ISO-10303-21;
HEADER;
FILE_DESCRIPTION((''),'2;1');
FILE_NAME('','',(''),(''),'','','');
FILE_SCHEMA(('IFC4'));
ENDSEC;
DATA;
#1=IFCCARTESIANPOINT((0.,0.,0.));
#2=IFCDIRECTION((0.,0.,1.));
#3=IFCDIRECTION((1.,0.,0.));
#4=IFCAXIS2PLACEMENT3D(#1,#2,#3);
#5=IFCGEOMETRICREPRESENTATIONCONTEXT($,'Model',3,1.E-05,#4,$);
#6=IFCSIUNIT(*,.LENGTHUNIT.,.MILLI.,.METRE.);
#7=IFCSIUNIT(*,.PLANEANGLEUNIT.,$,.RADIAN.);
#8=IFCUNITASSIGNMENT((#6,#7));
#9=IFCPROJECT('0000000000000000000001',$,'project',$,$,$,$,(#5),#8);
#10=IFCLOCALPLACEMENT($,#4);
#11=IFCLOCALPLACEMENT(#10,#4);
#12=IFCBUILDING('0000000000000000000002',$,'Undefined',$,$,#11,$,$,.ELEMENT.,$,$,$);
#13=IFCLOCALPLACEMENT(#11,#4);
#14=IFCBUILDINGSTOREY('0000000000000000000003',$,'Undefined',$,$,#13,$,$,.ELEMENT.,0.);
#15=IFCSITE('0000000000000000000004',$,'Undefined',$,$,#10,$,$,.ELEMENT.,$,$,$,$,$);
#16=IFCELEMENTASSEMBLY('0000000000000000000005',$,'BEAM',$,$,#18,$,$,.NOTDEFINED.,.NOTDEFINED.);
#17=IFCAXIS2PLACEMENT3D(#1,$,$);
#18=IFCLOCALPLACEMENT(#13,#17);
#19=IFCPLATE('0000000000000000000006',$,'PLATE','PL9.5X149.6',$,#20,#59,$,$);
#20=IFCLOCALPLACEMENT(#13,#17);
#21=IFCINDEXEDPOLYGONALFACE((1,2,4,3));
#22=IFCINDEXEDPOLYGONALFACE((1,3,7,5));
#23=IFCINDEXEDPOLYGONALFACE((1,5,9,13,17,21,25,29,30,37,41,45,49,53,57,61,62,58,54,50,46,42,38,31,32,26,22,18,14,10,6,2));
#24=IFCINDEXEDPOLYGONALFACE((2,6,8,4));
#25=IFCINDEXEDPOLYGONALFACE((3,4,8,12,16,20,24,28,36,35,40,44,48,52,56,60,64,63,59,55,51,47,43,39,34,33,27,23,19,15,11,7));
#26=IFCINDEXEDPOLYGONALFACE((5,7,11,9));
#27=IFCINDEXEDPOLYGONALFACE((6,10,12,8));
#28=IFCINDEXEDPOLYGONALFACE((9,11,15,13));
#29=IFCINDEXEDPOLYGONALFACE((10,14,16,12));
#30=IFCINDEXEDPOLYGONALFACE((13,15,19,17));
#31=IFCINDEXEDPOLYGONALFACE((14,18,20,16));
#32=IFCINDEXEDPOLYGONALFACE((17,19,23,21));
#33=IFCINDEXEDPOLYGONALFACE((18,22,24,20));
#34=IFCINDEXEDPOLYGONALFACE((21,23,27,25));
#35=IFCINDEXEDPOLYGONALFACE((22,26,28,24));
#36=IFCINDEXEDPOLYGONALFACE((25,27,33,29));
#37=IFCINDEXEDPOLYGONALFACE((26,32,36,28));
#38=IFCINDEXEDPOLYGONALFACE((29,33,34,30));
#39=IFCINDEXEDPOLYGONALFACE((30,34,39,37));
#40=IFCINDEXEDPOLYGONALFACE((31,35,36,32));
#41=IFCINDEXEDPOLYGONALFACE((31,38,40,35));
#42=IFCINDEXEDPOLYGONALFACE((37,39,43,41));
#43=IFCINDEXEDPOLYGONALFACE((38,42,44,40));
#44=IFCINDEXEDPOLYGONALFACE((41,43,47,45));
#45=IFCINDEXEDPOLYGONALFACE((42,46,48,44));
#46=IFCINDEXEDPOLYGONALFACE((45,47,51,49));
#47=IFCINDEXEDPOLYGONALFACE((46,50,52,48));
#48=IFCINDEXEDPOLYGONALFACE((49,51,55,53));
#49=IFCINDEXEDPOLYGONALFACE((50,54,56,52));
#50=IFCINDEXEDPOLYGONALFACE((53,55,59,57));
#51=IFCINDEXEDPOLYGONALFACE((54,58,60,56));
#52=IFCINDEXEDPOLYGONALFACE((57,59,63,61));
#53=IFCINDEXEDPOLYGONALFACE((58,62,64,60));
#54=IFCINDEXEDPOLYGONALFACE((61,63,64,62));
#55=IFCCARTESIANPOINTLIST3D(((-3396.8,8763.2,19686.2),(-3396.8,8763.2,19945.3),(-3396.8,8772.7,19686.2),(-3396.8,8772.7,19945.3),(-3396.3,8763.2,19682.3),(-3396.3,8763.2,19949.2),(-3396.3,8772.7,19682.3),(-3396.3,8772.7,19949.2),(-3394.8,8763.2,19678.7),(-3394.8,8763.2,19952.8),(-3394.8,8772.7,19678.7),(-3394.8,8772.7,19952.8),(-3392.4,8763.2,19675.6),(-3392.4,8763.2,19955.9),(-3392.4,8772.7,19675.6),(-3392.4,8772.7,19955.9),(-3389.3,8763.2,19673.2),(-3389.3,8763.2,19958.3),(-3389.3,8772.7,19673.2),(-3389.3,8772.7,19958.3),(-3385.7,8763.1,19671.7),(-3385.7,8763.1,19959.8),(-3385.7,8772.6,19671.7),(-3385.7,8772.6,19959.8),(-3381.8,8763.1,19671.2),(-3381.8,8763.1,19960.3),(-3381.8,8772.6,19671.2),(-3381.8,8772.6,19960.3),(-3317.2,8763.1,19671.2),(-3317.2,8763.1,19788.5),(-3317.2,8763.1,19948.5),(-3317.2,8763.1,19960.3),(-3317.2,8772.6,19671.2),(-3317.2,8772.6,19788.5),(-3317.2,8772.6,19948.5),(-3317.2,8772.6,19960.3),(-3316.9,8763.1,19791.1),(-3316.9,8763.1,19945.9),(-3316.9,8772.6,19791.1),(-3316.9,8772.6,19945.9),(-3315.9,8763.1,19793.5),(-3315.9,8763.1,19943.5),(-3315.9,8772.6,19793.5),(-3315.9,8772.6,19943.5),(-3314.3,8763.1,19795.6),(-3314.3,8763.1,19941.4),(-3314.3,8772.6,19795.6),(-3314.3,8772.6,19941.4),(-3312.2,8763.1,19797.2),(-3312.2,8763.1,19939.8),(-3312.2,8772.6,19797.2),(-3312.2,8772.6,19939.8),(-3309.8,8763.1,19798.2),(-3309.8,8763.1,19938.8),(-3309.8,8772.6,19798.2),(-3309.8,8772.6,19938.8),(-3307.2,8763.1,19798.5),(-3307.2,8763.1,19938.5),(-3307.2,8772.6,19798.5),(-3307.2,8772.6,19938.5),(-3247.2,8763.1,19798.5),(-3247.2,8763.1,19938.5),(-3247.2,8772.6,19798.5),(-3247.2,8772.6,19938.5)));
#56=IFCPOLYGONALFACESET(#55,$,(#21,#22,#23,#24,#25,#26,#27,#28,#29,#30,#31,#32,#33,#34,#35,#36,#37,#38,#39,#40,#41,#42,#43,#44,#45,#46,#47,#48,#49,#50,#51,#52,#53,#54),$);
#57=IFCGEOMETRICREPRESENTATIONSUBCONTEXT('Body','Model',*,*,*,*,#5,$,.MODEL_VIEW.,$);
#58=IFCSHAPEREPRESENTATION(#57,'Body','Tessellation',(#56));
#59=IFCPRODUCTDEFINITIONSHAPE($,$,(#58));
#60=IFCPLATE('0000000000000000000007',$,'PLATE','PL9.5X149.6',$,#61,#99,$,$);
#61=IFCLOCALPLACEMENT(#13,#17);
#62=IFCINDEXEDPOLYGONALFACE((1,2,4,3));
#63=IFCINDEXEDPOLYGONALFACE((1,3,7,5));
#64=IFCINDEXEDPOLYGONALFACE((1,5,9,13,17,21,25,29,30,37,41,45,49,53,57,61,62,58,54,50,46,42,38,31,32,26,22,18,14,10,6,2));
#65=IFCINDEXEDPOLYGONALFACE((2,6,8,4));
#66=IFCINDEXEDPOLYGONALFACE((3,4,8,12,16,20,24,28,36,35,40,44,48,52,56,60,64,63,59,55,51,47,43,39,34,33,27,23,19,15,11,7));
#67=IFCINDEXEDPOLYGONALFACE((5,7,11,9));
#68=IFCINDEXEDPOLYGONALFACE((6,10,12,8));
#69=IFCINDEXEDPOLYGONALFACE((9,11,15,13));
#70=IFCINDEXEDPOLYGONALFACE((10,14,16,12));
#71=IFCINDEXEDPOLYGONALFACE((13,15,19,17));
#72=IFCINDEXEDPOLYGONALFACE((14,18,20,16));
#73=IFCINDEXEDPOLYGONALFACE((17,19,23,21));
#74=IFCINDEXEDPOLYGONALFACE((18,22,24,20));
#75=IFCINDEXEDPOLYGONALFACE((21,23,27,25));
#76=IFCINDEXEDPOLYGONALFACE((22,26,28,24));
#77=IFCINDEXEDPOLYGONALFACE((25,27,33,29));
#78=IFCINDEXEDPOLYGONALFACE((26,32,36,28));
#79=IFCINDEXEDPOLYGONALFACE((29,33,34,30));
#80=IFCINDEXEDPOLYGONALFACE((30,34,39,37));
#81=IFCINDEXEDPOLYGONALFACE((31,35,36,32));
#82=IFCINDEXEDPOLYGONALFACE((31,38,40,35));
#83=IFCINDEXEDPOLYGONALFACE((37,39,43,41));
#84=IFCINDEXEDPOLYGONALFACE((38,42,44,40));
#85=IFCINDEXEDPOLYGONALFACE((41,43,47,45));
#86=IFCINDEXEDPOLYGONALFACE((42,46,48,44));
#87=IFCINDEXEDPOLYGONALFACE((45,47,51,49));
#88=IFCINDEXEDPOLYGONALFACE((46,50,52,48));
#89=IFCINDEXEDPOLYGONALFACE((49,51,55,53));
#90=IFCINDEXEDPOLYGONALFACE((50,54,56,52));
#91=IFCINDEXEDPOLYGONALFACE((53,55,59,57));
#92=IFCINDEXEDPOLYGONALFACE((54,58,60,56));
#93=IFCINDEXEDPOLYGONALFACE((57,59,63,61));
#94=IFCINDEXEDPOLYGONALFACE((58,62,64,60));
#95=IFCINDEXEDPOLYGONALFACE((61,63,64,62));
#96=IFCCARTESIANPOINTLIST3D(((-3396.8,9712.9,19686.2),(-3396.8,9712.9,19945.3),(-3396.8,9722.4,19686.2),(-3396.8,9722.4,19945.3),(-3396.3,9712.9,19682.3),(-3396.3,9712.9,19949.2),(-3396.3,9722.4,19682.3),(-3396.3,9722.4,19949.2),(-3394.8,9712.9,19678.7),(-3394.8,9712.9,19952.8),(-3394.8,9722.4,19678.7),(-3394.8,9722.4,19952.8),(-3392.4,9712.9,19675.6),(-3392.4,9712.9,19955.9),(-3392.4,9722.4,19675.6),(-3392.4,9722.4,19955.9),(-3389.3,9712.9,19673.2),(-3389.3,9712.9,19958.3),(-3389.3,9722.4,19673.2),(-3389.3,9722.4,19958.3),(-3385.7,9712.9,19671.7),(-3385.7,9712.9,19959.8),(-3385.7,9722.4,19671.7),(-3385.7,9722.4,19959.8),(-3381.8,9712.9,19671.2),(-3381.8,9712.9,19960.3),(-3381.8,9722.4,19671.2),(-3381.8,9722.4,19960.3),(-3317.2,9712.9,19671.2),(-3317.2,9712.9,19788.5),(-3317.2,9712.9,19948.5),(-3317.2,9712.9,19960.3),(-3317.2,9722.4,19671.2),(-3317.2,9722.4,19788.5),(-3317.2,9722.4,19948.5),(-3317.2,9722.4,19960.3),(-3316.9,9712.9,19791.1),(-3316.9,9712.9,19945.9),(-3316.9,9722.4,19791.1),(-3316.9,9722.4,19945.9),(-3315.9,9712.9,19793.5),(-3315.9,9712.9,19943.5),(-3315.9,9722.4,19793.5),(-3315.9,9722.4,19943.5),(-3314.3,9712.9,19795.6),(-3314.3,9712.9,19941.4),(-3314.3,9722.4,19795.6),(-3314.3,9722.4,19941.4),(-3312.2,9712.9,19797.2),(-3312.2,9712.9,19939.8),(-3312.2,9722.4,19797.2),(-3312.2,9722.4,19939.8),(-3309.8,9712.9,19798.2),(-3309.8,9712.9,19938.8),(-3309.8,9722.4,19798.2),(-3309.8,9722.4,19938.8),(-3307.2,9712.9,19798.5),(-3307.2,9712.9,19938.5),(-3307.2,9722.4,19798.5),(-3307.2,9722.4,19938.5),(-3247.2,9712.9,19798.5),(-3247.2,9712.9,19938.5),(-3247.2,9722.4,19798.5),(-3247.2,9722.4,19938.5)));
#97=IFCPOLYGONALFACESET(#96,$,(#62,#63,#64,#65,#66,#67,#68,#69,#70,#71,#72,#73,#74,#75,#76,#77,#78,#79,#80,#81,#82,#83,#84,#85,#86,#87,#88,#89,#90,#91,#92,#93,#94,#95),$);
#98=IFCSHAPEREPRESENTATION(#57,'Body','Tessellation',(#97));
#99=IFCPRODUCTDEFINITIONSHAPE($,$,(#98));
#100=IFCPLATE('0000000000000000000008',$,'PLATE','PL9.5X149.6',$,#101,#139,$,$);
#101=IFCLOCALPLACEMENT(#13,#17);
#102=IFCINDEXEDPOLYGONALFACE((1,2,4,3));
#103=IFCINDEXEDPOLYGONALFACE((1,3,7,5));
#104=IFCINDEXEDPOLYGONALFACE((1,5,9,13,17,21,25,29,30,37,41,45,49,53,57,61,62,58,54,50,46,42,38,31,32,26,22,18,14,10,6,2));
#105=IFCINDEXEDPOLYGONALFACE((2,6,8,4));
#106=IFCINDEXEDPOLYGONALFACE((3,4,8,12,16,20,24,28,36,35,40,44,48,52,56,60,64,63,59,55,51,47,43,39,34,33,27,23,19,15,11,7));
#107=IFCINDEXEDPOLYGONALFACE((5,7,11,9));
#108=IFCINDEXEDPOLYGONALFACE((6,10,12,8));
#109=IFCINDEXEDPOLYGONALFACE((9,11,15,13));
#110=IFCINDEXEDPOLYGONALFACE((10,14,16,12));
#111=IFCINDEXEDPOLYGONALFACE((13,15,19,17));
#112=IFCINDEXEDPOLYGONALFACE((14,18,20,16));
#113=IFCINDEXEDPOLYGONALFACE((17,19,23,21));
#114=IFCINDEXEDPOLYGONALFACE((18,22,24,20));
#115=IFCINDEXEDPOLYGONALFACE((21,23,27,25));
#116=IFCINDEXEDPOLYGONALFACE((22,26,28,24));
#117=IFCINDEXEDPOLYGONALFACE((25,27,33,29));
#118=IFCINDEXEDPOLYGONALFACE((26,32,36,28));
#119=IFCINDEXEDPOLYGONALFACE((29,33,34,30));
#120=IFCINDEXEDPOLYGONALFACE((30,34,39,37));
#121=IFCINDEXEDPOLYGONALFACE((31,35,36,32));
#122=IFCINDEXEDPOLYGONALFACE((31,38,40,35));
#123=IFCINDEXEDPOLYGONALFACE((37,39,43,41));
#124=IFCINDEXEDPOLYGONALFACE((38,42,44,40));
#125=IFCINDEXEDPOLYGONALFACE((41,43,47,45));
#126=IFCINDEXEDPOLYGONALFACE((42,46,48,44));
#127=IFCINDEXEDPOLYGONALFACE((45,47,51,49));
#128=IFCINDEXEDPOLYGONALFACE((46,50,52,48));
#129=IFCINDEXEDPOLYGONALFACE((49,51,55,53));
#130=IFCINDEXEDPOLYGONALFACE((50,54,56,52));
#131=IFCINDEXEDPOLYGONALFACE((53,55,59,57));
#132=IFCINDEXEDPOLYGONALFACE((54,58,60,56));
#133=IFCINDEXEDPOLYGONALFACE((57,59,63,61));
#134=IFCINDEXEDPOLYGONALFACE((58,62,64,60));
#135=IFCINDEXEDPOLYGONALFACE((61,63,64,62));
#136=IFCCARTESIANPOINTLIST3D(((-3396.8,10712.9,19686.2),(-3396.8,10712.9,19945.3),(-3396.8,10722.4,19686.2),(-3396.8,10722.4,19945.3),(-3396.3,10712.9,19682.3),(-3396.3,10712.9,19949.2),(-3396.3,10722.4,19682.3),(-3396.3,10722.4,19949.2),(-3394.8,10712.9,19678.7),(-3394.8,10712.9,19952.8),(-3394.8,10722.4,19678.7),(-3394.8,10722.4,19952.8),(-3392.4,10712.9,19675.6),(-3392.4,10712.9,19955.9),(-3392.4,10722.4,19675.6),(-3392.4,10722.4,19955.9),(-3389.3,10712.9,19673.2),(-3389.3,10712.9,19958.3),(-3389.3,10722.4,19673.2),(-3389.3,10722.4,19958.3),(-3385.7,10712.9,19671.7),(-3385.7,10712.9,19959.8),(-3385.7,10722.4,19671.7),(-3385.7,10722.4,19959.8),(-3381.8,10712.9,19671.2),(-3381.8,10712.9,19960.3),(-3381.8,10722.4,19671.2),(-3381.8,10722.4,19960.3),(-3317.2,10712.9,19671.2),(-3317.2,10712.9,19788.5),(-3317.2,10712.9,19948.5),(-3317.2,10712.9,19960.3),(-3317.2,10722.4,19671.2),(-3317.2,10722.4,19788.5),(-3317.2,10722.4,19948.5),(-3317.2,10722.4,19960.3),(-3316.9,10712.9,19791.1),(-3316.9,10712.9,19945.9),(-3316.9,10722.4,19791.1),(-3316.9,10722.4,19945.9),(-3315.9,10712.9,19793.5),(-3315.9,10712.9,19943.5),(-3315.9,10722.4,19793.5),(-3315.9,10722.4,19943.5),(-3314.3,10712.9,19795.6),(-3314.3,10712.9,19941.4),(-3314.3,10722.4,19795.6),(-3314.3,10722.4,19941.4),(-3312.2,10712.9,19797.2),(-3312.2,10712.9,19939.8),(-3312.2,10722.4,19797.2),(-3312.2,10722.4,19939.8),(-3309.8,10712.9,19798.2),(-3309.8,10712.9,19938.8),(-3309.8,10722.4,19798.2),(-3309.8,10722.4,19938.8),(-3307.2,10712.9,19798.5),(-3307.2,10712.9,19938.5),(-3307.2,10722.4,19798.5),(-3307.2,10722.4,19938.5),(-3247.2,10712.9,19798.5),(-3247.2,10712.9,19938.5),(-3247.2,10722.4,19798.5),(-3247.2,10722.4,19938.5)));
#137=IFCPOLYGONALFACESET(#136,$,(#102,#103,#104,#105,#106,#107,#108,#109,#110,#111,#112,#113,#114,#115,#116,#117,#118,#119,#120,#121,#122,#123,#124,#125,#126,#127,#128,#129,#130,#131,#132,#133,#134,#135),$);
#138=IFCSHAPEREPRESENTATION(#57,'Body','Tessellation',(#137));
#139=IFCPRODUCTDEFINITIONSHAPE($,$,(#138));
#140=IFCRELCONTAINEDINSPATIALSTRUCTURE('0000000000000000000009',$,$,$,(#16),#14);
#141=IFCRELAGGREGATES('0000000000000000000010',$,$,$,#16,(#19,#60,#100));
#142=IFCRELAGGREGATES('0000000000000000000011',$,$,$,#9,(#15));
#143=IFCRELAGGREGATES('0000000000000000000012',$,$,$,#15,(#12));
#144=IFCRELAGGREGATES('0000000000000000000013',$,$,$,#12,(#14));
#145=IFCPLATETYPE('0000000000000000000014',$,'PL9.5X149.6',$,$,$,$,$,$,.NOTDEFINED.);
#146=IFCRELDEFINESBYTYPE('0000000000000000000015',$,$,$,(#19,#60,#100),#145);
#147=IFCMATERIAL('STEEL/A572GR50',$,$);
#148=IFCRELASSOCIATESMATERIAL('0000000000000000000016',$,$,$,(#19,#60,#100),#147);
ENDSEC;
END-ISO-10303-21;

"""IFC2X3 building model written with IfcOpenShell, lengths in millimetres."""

from ifc_helpers import new_model, si_unit, frame, frame_2d, origin_with_axes, place, context, subcontext, project, spatial, polyline, circle_curve, parameter, trimmed, segment, composite_curve, outline, extrude, material, type_object, element, aggregate, save


model = new_model("IFC2X3")

# Units and contexts
model_context = context("Model", 3, precision=1e-05, world=origin_with_axes())
body_context = subcontext(model_context, "Body", "Model", "MODEL_VIEW")
ifc_project = project(units=[si_unit("LENGTHUNIT", "METRE", prefix="MILLI"), si_unit("PLANEANGLEUNIT", "RADIAN")], contexts=[model_context])

# Site, building, storey
site_placement = place(None, origin_with_axes())
site = spatial("IfcSite", under=ifc_project, at=site_placement, Name="Undefined", CompositionType="ELEMENT")
building_placement = place(site_placement, origin_with_axes())
building = spatial("IfcBuilding", under=site, at=building_placement, Name="Undefined", CompositionType="ELEMENT")
storey_placement = place(building_placement, origin_with_axes())
storey = spatial("IfcBuildingStorey", under=building, at=storey_placement, Name="Undefined", CompositionType="ELEMENT", Elevation=0.0)

# Element assembly
assembly_1_placement = place(storey_placement, origin_with_axes())
assembly_1 = element("IfcElementAssembly", 1, at=assembly_1_placement, inside=storey, Name="BEAM", AssemblyPlace="NOTDEFINED", PredefinedType="NOTDEFINED")
ifc_material_1 = material(Name="STEEL/A572GR50")

# Plates
plate_type_1 = type_object("IfcPlateType", Name="PL9.5X149.6", PredefinedType="NOTDEFINED")
plate_1_placement = place(assembly_1_placement, frame((-3396.8, 8767.9, 19960.3), z_axis=(-0.000056, -1.0, 0.0), x_axis=(0.0, 0.0, -1.0)))
plate_1 = element("IfcPlate", 2, at=plate_1_placement, type_object=plate_type_1, material=ifc_material_1, Name="PLATE", Description="PL9.5X149.6", context=body_context, shape_type="SweptSolid", body=[
    extrude(outline(composite_curve([segment(trimmed(circle_curve(frame_2d((15.0, 15.0), x_axis=(-1.0, 0.0)), 15.0), [parameter(0.0)], [parameter(1.570796)], True, "PARAMETER"), True, "CONTINUOUS"), segment(polyline([(15.0, 0.0), (274.1, 0.0)]), True, "CONTINUOUS"), segment(trimmed(circle_curve(frame_2d((274.1, 15.0), x_axis=(0.0, -1.0)), 15.0), [parameter(0.0)], [parameter(1.570796)], True, "PARAMETER"), True, "CONTINUOUS"), segment(polyline([(289.1, 15.0), (289.1, 79.6), (171.8, 79.6)]), True, "CONTINUOUS"), segment(trimmed(circle_curve(frame_2d((171.8, 89.6), x_axis=(0.0, -1.0)), 10.0), [parameter(0.0)], [parameter(4.712389)], False, "PARAMETER"), True, "CONTINUOUS"), segment(polyline([(161.8, 89.6), (161.8, 149.6), (21.8, 149.6), (21.8, 89.6)]), True, "CONTINUOUS"), segment(trimmed(circle_curve(frame_2d((11.8, 89.6), x_axis=(1.0, 0.0)), 10.0), [parameter(0.0)], [parameter(4.712389)], False, "PARAMETER"), True, "CONTINUOUS"), segment(polyline([(11.8, 79.6), (0.0, 79.6), (0.0, 15.0)]), True, "CONTINUOUS")], self_intersect=True)), frame((0.0, 0.0, -4.8), z_axis=(0.0, 0.0, 1.0), x_axis=(1.0, 0.0, 0.0)), (0.0, 0.0, 1.0), 9.5),
])
plate_2_placement = place(assembly_1_placement, frame((-3396.8, 9717.7, 19960.3), z_axis=(0.0, -1.0, 0.0), x_axis=(0.0, 0.0, -1.0)))
plate_2 = element("IfcPlate", 3, at=plate_2_placement, type_object=plate_type_1, material=ifc_material_1, Name="PLATE", Description="PL9.5X149.6", context=body_context, shape_type="SweptSolid", body=[
    extrude(outline(composite_curve([segment(trimmed(circle_curve(frame_2d((15.0, 15.0), x_axis=(-1.0, 0.0)), 15.0), [parameter(0.0)], [parameter(1.570796)], True, "PARAMETER"), True, "CONTINUOUS"), segment(polyline([(15.0, 0.0), (274.1, 0.0)]), True, "CONTINUOUS"), segment(trimmed(circle_curve(frame_2d((274.1, 15.0), x_axis=(0.0, -1.0)), 15.0), [parameter(0.0)], [parameter(1.570796)], True, "PARAMETER"), True, "CONTINUOUS"), segment(polyline([(289.1, 15.0), (289.1, 79.6), (171.8, 79.6)]), True, "CONTINUOUS"), segment(trimmed(circle_curve(frame_2d((171.8, 89.6), x_axis=(0.0, -1.0)), 10.0), [parameter(0.0)], [parameter(4.712389)], False, "PARAMETER"), True, "CONTINUOUS"), segment(polyline([(161.8, 89.6), (161.8, 149.6), (21.8, 149.6), (21.8, 89.6)]), True, "CONTINUOUS"), segment(trimmed(circle_curve(frame_2d((11.8, 89.6), x_axis=(1.0, 0.0)), 10.0), [parameter(0.0)], [parameter(4.712389)], False, "PARAMETER"), True, "CONTINUOUS"), segment(polyline([(11.8, 79.6), (0.0, 79.6), (0.0, 15.0)]), True, "CONTINUOUS")], self_intersect=True)), frame((0.0, 0.0, -4.8), z_axis=(0.0, 0.0, 1.0), x_axis=(1.0, 0.0, 0.0)), (0.0, 0.0, 1.0), 9.5),
])
plate_3_placement = place(assembly_1_placement, frame((-3396.8, 10717.7, 19960.3), z_axis=(0.0, -1.0, 0.0), x_axis=(0.0, 0.0, -1.0)))
plate_3 = element("IfcPlate", 4, at=plate_3_placement, type_object=plate_type_1, material=ifc_material_1, Name="PLATE", Description="PL9.5X149.6", context=body_context, shape_type="SweptSolid", body=[
    extrude(outline(composite_curve([segment(trimmed(circle_curve(frame_2d((15.0, 15.0), x_axis=(-1.0, 0.0)), 15.0), [parameter(0.0)], [parameter(1.570796)], True, "PARAMETER"), True, "CONTINUOUS"), segment(polyline([(15.0, 0.0), (274.1, 0.0)]), True, "CONTINUOUS"), segment(trimmed(circle_curve(frame_2d((274.1, 15.0), x_axis=(0.0, -1.0)), 15.0), [parameter(0.0)], [parameter(1.570796)], True, "PARAMETER"), True, "CONTINUOUS"), segment(polyline([(289.1, 15.0), (289.1, 79.6), (171.8, 79.6)]), True, "CONTINUOUS"), segment(trimmed(circle_curve(frame_2d((171.8, 89.6), x_axis=(0.0, -1.0)), 10.0), [parameter(0.0)], [parameter(4.712389)], False, "PARAMETER"), True, "CONTINUOUS"), segment(polyline([(161.8, 89.6), (161.8, 149.6), (21.8, 149.6), (21.8, 89.6)]), True, "CONTINUOUS"), segment(trimmed(circle_curve(frame_2d((11.8, 89.6), x_axis=(1.0, 0.0)), 10.0), [parameter(0.0)], [parameter(4.712389)], False, "PARAMETER"), True, "CONTINUOUS"), segment(polyline([(11.8, 79.6), (0.0, 79.6), (0.0, 15.0)]), True, "CONTINUOUS")], self_intersect=True)), frame((0.0, 0.0, -4.8), z_axis=(0.0, 0.0, 1.0), x_axis=(1.0, 0.0, 0.0)), (0.0, 0.0, 1.0), 9.5),
])

aggregate(assembly_1, [plate_1, plate_2, plate_3])

save(model, "model.ifc")
